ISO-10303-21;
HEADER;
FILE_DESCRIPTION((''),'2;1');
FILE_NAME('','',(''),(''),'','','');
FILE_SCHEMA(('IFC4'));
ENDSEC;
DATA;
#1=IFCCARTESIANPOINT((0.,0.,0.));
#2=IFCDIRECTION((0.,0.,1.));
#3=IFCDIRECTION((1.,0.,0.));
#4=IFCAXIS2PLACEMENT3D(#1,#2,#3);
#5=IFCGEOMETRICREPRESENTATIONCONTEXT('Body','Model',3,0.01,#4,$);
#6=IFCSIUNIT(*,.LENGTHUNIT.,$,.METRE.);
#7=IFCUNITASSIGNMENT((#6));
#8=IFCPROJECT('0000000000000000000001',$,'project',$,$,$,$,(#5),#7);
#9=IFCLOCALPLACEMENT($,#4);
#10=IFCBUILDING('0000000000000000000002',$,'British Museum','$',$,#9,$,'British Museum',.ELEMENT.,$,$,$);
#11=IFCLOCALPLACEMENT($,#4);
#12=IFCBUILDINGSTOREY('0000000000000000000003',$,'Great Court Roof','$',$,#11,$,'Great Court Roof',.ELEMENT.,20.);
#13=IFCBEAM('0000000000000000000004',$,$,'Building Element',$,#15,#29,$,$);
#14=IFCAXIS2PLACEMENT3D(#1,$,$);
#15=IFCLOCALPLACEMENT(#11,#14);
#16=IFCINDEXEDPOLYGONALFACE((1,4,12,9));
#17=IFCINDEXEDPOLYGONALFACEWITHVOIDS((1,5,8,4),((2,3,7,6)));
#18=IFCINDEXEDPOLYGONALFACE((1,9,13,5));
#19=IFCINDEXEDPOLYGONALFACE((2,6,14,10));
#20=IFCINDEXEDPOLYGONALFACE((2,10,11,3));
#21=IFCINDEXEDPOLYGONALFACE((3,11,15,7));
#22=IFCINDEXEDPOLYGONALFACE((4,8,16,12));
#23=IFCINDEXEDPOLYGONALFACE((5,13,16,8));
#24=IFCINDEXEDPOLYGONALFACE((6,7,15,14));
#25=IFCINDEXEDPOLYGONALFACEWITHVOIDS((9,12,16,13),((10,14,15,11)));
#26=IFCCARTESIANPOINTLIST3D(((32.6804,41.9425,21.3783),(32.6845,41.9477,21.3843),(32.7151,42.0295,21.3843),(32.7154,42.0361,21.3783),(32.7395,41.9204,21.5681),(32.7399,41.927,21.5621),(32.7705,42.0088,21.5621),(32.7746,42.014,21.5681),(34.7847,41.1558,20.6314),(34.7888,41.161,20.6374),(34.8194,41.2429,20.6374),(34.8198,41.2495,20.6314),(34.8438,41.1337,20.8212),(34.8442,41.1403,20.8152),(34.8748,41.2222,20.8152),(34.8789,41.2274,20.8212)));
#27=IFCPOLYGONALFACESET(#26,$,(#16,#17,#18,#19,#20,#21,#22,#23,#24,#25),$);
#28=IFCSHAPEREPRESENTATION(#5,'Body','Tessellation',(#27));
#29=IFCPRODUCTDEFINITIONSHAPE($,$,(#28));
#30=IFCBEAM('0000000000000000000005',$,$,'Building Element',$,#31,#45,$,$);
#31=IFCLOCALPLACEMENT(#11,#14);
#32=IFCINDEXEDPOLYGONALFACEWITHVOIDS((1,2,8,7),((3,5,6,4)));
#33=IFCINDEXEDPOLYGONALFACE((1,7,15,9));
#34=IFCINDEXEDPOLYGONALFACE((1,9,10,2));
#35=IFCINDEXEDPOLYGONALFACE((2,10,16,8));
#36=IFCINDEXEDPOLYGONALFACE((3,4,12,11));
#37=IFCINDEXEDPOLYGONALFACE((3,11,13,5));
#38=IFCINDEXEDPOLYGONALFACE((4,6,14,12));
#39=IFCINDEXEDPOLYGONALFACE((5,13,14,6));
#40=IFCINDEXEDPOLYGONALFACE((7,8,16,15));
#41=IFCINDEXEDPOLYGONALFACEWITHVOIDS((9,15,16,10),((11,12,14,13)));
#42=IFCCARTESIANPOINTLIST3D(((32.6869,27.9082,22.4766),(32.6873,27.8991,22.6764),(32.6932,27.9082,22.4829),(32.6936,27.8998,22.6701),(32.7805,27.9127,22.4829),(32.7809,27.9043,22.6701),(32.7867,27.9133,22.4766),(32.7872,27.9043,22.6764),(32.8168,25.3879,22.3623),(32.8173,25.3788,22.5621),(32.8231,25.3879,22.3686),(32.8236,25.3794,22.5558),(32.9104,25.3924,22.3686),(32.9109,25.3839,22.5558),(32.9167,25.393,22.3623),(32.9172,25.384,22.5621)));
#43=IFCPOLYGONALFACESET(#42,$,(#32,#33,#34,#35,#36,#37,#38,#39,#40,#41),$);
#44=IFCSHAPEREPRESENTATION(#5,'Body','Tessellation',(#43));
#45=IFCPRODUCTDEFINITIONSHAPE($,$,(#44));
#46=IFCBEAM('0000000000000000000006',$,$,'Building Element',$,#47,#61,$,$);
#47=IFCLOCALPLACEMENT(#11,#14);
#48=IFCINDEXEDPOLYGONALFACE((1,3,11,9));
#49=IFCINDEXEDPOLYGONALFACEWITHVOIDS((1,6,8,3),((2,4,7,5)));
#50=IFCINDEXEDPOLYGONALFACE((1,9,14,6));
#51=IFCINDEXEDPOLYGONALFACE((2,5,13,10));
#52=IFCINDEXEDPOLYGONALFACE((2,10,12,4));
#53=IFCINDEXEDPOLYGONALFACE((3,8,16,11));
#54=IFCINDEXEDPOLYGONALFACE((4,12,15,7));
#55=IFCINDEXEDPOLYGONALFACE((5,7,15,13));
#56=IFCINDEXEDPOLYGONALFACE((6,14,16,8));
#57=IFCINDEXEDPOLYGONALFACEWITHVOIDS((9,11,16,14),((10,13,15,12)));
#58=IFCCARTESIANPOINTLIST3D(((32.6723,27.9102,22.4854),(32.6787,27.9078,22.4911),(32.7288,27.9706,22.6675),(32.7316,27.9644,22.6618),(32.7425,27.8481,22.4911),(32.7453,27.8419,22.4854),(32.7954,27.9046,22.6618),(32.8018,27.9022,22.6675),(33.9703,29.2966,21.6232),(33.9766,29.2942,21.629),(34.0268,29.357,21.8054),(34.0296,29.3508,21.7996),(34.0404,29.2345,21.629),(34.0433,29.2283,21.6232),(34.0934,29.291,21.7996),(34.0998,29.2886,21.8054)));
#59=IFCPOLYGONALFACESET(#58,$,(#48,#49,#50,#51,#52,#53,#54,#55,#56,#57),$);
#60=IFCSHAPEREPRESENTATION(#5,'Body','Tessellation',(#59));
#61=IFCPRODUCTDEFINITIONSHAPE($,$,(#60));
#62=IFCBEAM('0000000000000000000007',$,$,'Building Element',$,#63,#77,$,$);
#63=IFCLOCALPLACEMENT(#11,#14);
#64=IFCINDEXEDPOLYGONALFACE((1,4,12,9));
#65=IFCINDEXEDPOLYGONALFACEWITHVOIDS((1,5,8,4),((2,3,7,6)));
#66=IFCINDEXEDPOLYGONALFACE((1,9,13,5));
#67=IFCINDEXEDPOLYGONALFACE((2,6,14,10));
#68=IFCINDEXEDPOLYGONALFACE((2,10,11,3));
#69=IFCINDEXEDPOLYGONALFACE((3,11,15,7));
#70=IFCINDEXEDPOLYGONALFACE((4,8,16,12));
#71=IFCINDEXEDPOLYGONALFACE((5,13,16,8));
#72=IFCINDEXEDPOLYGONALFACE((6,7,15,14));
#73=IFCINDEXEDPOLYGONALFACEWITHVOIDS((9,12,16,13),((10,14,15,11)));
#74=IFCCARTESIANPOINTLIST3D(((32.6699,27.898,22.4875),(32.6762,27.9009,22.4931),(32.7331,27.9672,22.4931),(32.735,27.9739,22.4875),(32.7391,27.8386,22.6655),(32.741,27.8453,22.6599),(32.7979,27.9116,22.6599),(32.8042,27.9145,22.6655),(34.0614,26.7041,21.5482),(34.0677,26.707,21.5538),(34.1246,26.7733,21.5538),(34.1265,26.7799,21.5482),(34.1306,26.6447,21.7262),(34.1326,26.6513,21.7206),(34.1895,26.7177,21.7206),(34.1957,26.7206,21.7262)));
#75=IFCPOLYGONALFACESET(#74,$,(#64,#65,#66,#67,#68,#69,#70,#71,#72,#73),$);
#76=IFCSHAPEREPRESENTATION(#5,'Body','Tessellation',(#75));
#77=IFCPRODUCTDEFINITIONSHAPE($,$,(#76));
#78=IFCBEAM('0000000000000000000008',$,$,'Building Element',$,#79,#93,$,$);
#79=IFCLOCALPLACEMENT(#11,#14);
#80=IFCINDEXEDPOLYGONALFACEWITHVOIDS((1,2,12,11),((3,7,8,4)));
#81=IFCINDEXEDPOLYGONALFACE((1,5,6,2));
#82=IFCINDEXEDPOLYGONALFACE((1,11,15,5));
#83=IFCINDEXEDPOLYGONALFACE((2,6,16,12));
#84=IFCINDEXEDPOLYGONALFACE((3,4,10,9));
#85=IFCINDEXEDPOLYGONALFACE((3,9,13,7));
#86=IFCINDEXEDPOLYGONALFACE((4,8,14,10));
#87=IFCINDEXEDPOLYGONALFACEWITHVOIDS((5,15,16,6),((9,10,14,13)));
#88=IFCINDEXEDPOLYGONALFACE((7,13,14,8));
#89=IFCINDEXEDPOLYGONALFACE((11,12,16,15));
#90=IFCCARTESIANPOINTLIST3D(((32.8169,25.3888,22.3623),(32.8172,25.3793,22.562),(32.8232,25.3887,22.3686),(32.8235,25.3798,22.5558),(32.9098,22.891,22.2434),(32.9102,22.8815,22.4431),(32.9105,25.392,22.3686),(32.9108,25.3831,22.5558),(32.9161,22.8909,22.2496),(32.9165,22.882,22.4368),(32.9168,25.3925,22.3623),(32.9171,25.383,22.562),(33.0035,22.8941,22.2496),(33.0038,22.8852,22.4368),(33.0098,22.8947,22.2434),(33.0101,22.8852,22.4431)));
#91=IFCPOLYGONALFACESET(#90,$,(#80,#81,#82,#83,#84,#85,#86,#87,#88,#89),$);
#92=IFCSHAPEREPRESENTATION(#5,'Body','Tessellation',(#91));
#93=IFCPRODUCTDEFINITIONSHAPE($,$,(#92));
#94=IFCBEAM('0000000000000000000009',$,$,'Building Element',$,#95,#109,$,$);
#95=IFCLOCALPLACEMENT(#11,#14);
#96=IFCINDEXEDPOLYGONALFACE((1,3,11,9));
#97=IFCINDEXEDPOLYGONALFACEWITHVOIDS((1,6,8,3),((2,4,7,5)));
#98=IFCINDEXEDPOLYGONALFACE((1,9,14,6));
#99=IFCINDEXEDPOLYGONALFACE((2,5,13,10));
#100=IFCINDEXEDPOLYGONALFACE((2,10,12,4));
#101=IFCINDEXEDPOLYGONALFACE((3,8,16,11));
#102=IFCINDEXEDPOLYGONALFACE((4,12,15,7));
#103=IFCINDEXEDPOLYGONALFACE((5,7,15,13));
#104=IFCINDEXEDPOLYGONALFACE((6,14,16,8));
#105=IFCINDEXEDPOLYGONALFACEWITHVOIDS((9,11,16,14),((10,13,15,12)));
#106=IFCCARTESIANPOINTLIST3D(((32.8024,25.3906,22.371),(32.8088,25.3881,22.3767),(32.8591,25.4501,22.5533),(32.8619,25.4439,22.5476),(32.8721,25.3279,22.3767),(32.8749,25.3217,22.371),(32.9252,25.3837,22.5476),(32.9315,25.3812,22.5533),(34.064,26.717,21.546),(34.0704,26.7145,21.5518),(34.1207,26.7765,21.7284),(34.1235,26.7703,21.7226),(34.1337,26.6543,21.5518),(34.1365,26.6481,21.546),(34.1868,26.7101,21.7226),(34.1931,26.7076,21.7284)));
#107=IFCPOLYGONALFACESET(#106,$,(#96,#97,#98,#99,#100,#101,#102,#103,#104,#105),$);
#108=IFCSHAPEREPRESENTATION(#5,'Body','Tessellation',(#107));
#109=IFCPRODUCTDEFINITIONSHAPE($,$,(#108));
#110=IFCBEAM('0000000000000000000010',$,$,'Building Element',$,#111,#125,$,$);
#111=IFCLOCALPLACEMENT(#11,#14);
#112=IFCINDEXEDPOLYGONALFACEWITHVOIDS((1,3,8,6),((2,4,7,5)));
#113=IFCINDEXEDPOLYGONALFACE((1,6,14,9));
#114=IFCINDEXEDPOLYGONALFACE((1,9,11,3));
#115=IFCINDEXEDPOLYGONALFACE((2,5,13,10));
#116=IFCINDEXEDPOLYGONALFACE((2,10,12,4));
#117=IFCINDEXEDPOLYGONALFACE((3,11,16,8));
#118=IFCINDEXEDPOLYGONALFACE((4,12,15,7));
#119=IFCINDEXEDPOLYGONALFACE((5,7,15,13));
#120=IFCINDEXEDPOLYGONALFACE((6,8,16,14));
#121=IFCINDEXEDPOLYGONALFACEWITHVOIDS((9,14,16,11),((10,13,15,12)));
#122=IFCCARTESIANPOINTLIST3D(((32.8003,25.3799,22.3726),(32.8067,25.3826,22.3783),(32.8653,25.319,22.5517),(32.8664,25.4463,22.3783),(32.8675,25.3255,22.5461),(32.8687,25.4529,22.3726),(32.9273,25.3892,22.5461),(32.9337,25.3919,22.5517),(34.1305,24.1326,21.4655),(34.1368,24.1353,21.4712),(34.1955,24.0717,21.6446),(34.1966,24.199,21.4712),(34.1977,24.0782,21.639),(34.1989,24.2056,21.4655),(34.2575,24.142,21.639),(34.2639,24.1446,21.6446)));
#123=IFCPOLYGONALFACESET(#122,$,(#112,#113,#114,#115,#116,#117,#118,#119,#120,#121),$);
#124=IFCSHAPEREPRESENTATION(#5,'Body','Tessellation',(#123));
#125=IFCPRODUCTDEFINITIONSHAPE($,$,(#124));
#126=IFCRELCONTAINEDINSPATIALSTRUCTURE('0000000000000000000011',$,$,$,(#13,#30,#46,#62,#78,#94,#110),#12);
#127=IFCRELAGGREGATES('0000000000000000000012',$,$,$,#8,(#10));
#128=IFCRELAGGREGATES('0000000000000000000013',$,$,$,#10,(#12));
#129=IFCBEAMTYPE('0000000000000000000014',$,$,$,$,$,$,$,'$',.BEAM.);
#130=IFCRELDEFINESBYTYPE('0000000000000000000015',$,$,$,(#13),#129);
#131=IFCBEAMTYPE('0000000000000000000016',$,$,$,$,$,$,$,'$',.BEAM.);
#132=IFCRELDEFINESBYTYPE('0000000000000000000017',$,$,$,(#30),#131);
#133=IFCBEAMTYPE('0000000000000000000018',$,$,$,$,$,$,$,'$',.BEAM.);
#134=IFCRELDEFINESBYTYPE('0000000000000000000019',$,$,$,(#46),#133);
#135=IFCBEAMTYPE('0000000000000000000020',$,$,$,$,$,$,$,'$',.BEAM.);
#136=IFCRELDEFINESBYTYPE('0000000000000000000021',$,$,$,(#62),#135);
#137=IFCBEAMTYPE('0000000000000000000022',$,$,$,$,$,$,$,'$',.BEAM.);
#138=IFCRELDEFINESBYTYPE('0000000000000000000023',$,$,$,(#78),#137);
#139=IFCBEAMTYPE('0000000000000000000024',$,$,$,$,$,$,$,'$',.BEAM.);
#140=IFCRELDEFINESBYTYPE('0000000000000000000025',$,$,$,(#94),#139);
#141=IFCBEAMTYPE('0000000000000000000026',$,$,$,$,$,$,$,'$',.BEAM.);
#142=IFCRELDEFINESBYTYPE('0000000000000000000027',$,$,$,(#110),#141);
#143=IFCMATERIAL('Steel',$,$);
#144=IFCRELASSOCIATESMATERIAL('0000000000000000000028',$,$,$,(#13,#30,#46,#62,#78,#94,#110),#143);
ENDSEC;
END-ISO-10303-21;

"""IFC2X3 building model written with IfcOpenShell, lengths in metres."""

from ifc_helpers import new_model, si_unit, frame, origin_with_axes, origin_2d, place, context, project, spatial, hollow_rectangle, extrude, material, type_object, element, save


model = new_model("IFC2X3")

# Units and contexts
model_context = context("Model", 3, precision=0.01, world=origin_with_axes(), identifier="Body")
ifc_project = project(units=[si_unit("LENGTHUNIT", "METRE")], contexts=[model_context])

# Building, storey
building_placement = place(None, origin_with_axes())
building = spatial("IfcBuilding", under=ifc_project, at=building_placement, Name="British Museum", Description="$", LongName="British Museum", CompositionType="ELEMENT")
storey_placement = place(None, origin_with_axes())
storey = spatial("IfcBuildingStorey", under=building, at=storey_placement, Name="Great Court Roof", Description="$", LongName="Great Court Roof", CompositionType="ELEMENT", Elevation=20.0)

# Beams
ifc_material = material(Name="Steel")
beam_type_1 = type_object("IfcBeamType", ElementType="$", PredefinedType="BEAM")
beam_1_placement = place(None, origin_with_axes())
element("IfcBeam", 1, at=beam_1_placement, inside=storey, type_object=beam_type_1, material=ifc_material, Description="Building Element", context=model_context, shape_type="SweptSolid", body=[
    extrude(hollow_rectangle(XDim=0.1, YDim=0.2, WallThickness=0.0063, InnerFilletRadius=0.0, OuterFilletRadius=0.0, at=origin_2d()), frame((32.7275, 41.9782, 21.4732), z_axis=(0.88885, -0.332282, -0.31549), x_axis=(0.350165, 0.936688, 0.0)), (0.0, 0.0, 1.0), 2.3674),
])
beam_type_2 = type_object("IfcBeamType", ElementType="$", PredefinedType="BEAM")
beam_2_placement = place(None, origin_with_axes())
element("IfcBeam", 2, at=beam_2_placement, inside=storey, type_object=beam_type_2, material=ifc_material, Description="Building Element", context=model_context, shape_type="SweptSolid", body=[
    extrude(hollow_rectangle(XDim=0.1, YDim=0.2, WallThickness=0.0063, InnerFilletRadius=0.0, OuterFilletRadius=0.0, at=origin_2d()), frame((32.737, 27.9062, 22.5765), z_axis=(0.05144, -0.99765, -0.045248), x_axis=(0.998673, 0.051493, 0.0)), (0.0, 0.0, 1.0), 2.5263),
])
beam_type_3 = type_object("IfcBeamType", ElementType="$", PredefinedType="BEAM")
beam_3_placement = place(None, origin_with_axes())
element("IfcBeam", 3, at=beam_3_placement, inside=storey, type_object=beam_type_3, material=ifc_material, Description="Building Element", context=model_context, shape_type="SweptSolid", body=[
    extrude(hollow_rectangle(XDim=0.1, YDim=0.2, WallThickness=0.0063, InnerFilletRadius=0.0, OuterFilletRadius=0.0, at=origin_2d()), frame((32.737, 27.9062, 22.5765), z_axis=(0.622318, 0.664711, -0.413375), x_axis=(-0.730002, 0.683445, 0.0)), (0.0, 0.0, 1.0), 2.0857),
])
beam_type_4 = type_object("IfcBeamType", ElementType="$", PredefinedType="BEAM")
beam_4_placement = place(None, origin_with_axes())
element("IfcBeam", 4, at=beam_4_placement, inside=storey, type_object=beam_type_4, material=ifc_material, Description="Building Element", context=model_context, shape_type="SweptSolid", body=[
    extrude(hollow_rectangle(XDim=0.1, YDim=0.2, WallThickness=0.0063, InnerFilletRadius=0.0, OuterFilletRadius=0.0, at=origin_2d()), frame((32.737, 27.9062, 22.5765), z_axis=(0.675467, -0.579541, -0.455935), x_axis=(0.65116, 0.75894, 0.0)), (0.0, 0.0, 1.0), 2.0601),
])
beam_type_5 = type_object("IfcBeamType", ElementType="$", PredefinedType="BEAM")
beam_5_placement = place(None, origin_with_axes())
element("IfcBeam", 5, at=beam_5_placement, inside=storey, type_object=beam_type_5, material=ifc_material, Description="Building Element", context=model_context, shape_type="SweptSolid", body=[
    extrude(hollow_rectangle(XDim=0.1, YDim=0.2, WallThickness=0.0063, InnerFilletRadius=0.0, OuterFilletRadius=0.0, at=origin_2d()), frame((32.867, 25.3859, 22.4622), z_axis=(0.037161, -0.998179, -0.047523), x_axis=(0.999308, 0.037203, 0.0)), (0.0, 0.0, 1.0), 2.5024),
])
beam_type_6 = type_object("IfcBeamType", ElementType="$", PredefinedType="BEAM")
beam_6_placement = place(None, origin_with_axes())
element("IfcBeam", 6, at=beam_6_placement, inside=storey, type_object=beam_type_6, material=ifc_material, Description="Building Element", context=model_context, shape_type="SweptSolid", body=[
    extrude(hollow_rectangle(XDim=0.1, YDim=0.2, WallThickness=0.0063, InnerFilletRadius=0.0, OuterFilletRadius=0.0, at=origin_2d()), frame((32.867, 25.3859, 22.4622), z_axis=(0.628325, 0.6606, -0.410871), x_axis=(-0.724586, 0.689185, 0.0)), (0.0, 0.0, 1.0), 2.0079),
])
beam_type_7 = type_object("IfcBeamType", ElementType="$", PredefinedType="BEAM")
beam_7_placement = place(None, origin_with_axes())
element("IfcBeam", 7, at=beam_7_placement, inside=storey, type_object=beam_type_7, material=ifc_material, Description="Building Element", context=model_context, shape_type="SweptSolid", body=[
    extrude(hollow_rectangle(XDim=0.1, YDim=0.2, WallThickness=0.0063, InnerFilletRadius=0.0, OuterFilletRadius=0.0, at=origin_2d()), frame((32.867, 25.3859, 22.4622), z_axis=(0.653122, -0.612427, -0.44538), x_axis=(0.684015, 0.729467, 0.0)), (0.0, 0.0, 1.0), 2.0366),
])

save(model, "model.ifc")
